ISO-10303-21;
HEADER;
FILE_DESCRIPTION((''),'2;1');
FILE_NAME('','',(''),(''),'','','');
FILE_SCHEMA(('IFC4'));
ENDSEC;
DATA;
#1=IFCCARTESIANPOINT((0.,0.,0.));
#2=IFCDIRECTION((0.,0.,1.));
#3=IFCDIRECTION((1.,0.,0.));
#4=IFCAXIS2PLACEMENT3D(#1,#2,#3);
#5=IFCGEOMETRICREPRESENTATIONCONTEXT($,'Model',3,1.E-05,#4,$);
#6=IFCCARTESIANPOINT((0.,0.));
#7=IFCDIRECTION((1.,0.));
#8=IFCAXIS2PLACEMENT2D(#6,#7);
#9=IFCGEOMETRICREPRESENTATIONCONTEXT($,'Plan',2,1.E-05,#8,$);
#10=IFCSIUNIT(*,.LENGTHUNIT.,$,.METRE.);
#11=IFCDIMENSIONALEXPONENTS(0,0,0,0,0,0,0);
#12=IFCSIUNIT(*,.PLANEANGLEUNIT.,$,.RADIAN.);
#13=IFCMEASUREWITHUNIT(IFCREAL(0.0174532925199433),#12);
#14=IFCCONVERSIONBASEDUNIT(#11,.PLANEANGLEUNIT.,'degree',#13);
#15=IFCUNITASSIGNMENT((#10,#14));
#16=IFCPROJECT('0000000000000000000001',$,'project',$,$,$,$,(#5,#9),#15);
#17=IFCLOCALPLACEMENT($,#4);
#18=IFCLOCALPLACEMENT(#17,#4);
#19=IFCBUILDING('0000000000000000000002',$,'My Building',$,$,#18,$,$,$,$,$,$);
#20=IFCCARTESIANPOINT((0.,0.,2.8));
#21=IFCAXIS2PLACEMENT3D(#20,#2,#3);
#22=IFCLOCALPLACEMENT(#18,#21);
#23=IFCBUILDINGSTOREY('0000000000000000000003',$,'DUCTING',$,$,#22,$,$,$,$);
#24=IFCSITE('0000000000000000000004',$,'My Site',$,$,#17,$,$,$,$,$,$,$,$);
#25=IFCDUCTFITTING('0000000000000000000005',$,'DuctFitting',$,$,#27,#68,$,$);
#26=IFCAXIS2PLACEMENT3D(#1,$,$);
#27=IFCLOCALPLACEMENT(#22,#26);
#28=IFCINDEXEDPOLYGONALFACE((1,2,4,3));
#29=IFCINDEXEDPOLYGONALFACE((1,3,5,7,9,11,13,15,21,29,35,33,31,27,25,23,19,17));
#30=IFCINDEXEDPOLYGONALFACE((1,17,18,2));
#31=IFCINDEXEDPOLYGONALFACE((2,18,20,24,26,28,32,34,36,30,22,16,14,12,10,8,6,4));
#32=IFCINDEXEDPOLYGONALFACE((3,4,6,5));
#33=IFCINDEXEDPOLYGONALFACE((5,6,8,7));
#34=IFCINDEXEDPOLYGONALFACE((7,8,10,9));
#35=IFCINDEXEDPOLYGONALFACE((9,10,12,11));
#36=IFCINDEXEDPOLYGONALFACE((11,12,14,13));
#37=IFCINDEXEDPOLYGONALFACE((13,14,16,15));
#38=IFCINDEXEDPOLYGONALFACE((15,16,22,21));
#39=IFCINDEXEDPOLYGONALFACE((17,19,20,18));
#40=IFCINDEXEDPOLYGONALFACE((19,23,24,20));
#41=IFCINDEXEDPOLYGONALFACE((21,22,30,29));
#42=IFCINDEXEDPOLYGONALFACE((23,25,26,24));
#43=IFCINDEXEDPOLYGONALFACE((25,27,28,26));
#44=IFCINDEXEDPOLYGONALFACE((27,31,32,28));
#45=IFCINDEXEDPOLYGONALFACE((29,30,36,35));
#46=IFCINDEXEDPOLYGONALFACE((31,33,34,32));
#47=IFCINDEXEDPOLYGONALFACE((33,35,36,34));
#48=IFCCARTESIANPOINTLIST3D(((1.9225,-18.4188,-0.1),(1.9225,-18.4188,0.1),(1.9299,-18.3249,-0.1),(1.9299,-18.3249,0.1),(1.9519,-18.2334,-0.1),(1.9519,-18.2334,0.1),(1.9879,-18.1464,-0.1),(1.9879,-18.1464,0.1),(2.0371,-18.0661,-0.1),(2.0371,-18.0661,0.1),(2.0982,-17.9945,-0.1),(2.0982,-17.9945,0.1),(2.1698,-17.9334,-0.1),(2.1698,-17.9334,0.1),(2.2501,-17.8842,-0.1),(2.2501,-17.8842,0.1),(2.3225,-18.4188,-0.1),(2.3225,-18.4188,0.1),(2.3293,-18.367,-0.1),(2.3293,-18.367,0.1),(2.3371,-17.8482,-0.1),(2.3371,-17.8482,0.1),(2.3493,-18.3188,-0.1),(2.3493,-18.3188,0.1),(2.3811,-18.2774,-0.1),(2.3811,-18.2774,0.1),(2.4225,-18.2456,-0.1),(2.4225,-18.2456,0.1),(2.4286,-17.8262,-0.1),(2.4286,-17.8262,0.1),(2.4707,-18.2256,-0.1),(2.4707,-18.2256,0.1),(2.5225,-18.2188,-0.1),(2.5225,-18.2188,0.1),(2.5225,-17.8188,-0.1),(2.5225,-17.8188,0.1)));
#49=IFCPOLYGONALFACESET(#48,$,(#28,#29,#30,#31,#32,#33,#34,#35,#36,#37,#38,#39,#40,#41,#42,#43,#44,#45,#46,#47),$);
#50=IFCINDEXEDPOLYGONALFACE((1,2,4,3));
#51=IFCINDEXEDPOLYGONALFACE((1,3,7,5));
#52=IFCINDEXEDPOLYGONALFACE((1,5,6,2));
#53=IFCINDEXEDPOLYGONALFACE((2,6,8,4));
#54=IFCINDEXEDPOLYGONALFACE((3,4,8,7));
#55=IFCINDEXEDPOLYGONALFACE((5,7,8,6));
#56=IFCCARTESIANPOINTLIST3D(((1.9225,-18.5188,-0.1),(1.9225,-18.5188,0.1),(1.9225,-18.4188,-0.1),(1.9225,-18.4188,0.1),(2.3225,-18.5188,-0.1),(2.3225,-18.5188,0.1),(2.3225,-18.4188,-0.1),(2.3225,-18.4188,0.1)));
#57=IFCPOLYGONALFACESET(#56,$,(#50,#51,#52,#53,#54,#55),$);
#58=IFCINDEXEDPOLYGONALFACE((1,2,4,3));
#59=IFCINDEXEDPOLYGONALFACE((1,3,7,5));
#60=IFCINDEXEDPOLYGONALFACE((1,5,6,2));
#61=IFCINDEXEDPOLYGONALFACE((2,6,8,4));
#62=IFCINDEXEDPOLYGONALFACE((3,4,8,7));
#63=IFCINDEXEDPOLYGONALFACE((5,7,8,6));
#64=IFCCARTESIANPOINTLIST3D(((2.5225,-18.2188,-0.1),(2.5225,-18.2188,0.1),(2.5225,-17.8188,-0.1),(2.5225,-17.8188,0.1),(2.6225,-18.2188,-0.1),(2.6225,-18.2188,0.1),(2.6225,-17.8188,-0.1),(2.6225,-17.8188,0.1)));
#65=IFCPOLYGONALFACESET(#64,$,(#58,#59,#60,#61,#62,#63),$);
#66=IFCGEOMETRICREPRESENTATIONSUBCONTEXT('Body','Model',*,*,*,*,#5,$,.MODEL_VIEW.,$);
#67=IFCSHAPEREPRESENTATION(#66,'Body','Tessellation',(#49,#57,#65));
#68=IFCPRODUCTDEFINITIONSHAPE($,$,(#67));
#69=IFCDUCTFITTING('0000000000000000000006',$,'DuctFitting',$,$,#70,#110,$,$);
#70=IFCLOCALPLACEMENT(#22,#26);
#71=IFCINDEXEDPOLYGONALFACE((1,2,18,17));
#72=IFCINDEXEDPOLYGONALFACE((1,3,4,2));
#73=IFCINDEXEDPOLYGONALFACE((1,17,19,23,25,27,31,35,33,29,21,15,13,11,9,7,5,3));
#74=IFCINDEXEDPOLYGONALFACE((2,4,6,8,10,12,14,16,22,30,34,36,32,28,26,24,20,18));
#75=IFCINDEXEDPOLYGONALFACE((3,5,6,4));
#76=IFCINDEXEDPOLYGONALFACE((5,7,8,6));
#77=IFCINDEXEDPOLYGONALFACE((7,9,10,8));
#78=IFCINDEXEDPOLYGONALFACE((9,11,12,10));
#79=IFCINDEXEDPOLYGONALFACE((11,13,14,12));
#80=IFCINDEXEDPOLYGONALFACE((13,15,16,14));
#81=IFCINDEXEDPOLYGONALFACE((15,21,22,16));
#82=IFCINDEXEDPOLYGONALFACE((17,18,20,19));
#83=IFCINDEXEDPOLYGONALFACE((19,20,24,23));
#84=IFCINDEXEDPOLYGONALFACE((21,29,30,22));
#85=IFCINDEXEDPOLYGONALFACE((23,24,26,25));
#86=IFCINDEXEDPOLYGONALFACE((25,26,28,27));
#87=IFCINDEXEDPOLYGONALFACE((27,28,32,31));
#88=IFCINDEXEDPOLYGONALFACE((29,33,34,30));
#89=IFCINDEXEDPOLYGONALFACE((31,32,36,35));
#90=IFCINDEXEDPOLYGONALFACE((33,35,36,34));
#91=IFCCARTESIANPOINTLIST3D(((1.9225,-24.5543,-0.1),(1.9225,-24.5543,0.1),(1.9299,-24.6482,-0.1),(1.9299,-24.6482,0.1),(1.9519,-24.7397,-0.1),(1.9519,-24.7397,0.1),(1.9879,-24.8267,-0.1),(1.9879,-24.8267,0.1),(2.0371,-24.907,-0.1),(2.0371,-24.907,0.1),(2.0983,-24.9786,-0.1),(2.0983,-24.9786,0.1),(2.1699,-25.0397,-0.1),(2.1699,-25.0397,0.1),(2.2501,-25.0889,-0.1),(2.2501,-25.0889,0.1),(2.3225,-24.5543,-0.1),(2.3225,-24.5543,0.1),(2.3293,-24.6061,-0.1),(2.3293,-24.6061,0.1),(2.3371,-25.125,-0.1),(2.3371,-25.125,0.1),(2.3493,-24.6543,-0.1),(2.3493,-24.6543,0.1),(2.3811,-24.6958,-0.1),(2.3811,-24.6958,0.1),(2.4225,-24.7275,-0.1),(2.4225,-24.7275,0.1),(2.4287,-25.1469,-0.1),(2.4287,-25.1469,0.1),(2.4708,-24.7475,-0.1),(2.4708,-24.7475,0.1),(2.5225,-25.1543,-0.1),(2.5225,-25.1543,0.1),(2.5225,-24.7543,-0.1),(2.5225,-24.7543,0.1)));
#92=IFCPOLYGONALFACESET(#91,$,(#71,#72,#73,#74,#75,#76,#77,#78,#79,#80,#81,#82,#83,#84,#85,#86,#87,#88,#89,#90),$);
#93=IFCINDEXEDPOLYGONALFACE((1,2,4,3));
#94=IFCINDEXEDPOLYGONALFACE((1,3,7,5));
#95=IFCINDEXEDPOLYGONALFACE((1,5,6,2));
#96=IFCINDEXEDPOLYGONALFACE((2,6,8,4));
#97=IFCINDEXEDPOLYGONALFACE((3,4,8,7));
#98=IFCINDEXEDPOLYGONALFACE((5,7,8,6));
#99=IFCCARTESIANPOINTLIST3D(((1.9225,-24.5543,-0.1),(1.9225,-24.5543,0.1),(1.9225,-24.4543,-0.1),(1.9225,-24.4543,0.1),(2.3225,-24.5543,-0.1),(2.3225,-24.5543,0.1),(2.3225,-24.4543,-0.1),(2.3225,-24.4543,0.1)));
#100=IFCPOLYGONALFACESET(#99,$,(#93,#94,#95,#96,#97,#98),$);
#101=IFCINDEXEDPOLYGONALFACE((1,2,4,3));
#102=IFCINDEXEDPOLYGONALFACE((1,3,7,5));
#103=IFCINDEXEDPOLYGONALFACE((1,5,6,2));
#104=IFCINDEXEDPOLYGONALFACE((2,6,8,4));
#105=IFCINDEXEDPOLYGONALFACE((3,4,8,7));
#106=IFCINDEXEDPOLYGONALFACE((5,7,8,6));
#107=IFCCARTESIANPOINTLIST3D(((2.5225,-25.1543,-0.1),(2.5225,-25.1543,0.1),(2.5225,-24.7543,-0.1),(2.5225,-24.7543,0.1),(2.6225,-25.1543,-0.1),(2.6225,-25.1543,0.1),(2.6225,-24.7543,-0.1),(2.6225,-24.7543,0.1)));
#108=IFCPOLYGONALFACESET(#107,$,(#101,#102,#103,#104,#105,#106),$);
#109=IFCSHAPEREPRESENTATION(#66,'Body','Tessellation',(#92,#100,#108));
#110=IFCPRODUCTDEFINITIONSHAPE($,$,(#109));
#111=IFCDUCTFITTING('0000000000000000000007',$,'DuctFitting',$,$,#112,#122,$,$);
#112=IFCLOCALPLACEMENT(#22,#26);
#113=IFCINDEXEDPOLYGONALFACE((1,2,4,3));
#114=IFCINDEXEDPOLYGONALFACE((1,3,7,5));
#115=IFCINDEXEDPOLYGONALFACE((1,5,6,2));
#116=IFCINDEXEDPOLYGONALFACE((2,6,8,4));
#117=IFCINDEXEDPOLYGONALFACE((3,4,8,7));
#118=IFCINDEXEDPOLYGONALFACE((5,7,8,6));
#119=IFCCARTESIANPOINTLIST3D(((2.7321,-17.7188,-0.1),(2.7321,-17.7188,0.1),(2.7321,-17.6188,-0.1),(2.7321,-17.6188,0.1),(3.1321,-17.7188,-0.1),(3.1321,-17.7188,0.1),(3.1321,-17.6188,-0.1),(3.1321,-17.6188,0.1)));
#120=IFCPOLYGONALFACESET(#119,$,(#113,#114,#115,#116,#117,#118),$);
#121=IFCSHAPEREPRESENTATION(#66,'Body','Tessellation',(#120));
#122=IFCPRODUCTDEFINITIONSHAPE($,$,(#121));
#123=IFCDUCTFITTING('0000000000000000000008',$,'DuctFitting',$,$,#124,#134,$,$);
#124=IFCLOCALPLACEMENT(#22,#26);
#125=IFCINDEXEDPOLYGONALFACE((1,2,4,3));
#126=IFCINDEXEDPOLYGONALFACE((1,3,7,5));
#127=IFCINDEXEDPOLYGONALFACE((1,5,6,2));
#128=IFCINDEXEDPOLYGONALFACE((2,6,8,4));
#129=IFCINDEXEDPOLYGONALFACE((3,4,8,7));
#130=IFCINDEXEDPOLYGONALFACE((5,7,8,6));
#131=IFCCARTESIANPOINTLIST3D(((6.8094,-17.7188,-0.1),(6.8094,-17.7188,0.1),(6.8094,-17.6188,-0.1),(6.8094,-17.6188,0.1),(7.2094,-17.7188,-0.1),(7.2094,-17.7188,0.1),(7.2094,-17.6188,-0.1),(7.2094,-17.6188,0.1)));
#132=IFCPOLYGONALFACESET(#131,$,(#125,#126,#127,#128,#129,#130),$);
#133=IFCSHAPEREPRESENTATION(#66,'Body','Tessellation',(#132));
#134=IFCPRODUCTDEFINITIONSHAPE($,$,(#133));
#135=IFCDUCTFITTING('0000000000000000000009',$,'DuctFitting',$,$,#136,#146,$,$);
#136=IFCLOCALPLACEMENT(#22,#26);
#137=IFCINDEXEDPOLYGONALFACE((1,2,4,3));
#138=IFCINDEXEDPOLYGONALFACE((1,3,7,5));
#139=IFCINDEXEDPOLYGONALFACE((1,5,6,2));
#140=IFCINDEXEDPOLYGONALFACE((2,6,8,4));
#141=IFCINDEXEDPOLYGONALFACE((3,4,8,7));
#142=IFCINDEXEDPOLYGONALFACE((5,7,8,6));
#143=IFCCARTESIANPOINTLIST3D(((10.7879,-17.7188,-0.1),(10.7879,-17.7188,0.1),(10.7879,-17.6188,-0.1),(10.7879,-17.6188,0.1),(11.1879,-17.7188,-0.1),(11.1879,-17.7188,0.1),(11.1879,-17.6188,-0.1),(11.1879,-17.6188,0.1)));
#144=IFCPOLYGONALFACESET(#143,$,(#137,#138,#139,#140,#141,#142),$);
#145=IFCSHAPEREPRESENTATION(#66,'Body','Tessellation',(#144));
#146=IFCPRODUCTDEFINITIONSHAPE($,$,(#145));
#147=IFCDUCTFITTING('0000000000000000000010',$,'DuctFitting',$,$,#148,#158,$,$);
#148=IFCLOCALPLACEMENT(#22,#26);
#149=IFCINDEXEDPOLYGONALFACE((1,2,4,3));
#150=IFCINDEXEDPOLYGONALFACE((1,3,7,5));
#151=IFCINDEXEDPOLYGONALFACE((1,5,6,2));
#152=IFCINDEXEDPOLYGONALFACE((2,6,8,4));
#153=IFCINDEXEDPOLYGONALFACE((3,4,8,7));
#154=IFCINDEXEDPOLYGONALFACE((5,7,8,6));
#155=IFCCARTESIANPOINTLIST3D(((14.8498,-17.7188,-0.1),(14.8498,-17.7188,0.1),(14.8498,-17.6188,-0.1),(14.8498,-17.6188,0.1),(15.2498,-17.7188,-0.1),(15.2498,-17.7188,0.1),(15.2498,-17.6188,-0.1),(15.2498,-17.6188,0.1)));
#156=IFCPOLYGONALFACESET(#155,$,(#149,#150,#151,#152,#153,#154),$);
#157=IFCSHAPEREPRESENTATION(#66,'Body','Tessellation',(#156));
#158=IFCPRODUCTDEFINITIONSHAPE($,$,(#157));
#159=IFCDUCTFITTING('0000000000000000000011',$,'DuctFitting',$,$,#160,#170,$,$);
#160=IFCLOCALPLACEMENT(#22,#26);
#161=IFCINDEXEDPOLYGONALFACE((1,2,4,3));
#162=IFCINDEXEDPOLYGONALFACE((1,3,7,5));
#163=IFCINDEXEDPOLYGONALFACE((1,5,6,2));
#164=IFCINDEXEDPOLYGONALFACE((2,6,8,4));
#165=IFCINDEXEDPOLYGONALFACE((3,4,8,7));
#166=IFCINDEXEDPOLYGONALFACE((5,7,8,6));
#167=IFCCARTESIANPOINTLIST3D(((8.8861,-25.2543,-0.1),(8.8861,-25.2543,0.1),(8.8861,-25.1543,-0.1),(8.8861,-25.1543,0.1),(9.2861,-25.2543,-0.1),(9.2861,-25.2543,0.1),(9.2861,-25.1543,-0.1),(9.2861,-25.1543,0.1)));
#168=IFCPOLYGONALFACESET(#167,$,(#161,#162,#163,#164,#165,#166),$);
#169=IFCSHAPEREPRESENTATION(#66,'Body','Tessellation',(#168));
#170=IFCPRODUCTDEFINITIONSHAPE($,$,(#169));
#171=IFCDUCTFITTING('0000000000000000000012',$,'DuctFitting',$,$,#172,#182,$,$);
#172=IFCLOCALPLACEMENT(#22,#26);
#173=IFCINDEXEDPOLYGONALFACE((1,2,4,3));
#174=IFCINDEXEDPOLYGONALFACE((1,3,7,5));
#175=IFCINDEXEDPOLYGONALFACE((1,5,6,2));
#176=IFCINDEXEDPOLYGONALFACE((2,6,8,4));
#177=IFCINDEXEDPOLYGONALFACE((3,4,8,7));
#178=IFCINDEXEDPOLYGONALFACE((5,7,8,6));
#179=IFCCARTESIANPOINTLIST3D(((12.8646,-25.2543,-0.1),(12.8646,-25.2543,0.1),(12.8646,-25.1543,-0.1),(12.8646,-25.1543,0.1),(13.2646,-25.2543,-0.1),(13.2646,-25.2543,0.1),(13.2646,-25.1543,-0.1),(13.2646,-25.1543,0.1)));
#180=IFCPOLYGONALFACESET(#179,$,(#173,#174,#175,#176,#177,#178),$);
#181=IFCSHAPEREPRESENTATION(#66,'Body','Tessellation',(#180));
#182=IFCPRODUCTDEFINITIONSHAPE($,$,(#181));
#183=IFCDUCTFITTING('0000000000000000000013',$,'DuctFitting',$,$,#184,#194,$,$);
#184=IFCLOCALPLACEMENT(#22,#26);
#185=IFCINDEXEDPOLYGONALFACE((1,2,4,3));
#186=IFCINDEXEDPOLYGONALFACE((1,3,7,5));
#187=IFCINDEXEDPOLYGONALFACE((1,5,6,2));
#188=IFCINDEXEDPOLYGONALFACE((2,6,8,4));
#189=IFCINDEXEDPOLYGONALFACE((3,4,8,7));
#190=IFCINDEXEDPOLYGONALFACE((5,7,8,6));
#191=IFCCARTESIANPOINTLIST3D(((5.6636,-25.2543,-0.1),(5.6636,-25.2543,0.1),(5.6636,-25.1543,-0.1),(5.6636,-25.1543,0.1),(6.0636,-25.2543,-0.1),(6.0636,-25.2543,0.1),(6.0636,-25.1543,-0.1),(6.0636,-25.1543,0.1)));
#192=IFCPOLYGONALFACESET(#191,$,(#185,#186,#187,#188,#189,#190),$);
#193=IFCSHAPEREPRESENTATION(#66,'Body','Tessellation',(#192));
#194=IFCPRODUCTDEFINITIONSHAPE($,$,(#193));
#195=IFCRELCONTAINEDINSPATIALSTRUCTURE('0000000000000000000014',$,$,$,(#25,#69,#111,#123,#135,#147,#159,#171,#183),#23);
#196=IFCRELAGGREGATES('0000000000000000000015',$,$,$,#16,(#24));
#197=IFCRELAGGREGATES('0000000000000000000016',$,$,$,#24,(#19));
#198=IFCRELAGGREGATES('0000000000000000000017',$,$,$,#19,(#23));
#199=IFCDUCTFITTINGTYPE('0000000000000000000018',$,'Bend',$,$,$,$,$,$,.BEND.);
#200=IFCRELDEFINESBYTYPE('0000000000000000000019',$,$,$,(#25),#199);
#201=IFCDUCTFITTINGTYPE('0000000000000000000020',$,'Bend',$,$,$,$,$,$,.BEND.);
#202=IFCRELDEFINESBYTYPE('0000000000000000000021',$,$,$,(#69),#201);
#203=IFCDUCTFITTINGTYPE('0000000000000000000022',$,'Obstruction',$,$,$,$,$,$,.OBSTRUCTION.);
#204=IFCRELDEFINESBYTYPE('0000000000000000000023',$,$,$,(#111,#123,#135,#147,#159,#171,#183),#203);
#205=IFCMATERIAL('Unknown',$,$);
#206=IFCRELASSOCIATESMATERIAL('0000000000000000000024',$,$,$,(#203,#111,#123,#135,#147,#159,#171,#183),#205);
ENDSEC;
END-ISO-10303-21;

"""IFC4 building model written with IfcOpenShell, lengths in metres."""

from ifc_helpers import new_model, entity, si_unit, converted_unit, frame, origin_with_axes, origin_2d_with_axis, place, context, subcontext, project, spatial, line, arc, indexed_curve, rectangle, outline, extrude, source, transform, mapped, material, material_profile, profile_set, profile_usage, type_object, type_shapes, element, save


model = new_model("IFC4")

# Units and contexts
model_context = context("Model", 3, precision=1e-05, world=origin_with_axes())
plan_context = context("Plan", 2, precision=1e-05, world=origin_2d_with_axis())
body_context = subcontext(model_context, "Body", "Model", "MODEL_VIEW")
ifc_project = project(units=[si_unit("LENGTHUNIT", "METRE"), converted_unit("PLANEANGLEUNIT", "degree", entity("IfcReal", 0.0174532925199433), si_unit("PLANEANGLEUNIT", "RADIAN"), dimensions=[0, 0, 0, 0, 0, 0, 0])], contexts=[model_context, plan_context])

# Site, building, storey
site_placement = place(None, origin_with_axes())
site = spatial("IfcSite", under=ifc_project, at=site_placement, Name="My Site")
building_placement = place(site_placement, origin_with_axes())
building = spatial("IfcBuilding", under=site, at=building_placement, Name="My Building")
storey_placement = place(building_placement, frame((0.0, 0.0, 2.8), z_axis=(0.0, 0.0, 1.0), x_axis=(1.0, 0.0, 0.0)))
storey = spatial("IfcBuildingStorey", under=building, at=storey_placement, Name="DUCTING")

# Shared definitions
ifc_material = material(Name="Unknown")

# Duct fittings
duct_fitting_type_1 = type_object("IfcDuctFittingType", Name="Bend", PredefinedType="BEND")
shared_shape_1 = source(origin_with_axes(), body_context, "Body", "SweptSolid", [
    extrude(outline(indexed_curve([(-0.2, 0.0), (-0.2586, 0.1414), (-0.4, 0.2), (-0.4, 0.6), (0.0243, 0.4243), (0.2, 0.0)], segments=[arc(1, 2, 3), line(3, 4), arc(4, 5, 6), line(6, 1)])), frame((0.0, -0.1, 0.1), z_axis=(0.0, -1.0, 0.0), x_axis=(1.0, 0.0, 0.0)), (0.0, 0.0, -1.0), 0.2),
    extrude(rectangle(XDim=0.4, YDim=0.2), origin_with_axes(), (0.0, 0.0, 1.0), 0.1),
    extrude(rectangle(XDim=0.4, YDim=0.2), frame((-0.4, 0.0, 0.5), z_axis=(-1.0, 0.0, -0.000007), x_axis=(0.000007, 0.0, -1.0)), (0.0, 0.0, 1.0), 0.1),
])
type_shapes(duct_fitting_type_1, [shared_shape_1])
duct_fitting_1_placement = place(storey_placement, frame((2.1225, -18.5188, 0.0), z_axis=(-0.000006, 1.0, 0.0), x_axis=(-1.0, -0.000006, 0.0)))
element("IfcDuctFitting", 1, at=duct_fitting_1_placement, inside=storey, type_object=duct_fitting_type_1, Name="DuctFitting", context=body_context, shape_type="MappedRepresentation", body=[
    mapped(shared_shape_1, transform((0.0, 0.0, 0.0), x_axis=(1.0, 0.0, 0.0), y_axis=(0.0, 1.0, 0.0), z_axis=(0.0, 0.0, 1.0), scale=1.0)),
])
duct_fitting_type_2 = type_object("IfcDuctFittingType", Name="Bend", PredefinedType="BEND")
shared_shape_2 = source(origin_with_axes(), body_context, "Body", "SweptSolid", [
    extrude(outline(indexed_curve([(-0.2, 0.0), (-0.2586, -0.1414), (-0.4, -0.2), (-0.4, -0.6), (0.0243, -0.4243), (0.2, 0.0)], segments=[arc(1, 2, 3), line(3, 4), arc(4, 5, 6), line(6, 1)])), frame((0.0, -0.1, -0.1), z_axis=(0.0, -1.0, 0.0), x_axis=(1.0, 0.0, 0.0)), (0.0, 0.0, -1.0), 0.2),
    extrude(rectangle(XDim=0.4, YDim=0.2), origin_with_axes(), (0.0, 0.0, -1.0), 0.1),
    extrude(rectangle(XDim=0.4, YDim=0.2), frame((-0.4, 0.0, -0.5), z_axis=(-1.0, 0.0, -0.000007), x_axis=(0.000007, 0.0, -1.0)), (0.0, 0.0, 1.0), 0.1),
])
type_shapes(duct_fitting_type_2, [shared_shape_2])
duct_fitting_2_placement = place(storey_placement, frame((2.1225, -24.4543, 0.0), z_axis=(-0.000006, 1.0, 0.0), x_axis=(-1.0, -0.000006, 0.0)))
element("IfcDuctFitting", 2, at=duct_fitting_2_placement, inside=storey, type_object=duct_fitting_type_2, Name="DuctFitting", context=body_context, shape_type="MappedRepresentation", body=[
    mapped(shared_shape_2, transform((0.0, 0.0, 0.0), x_axis=(1.0, 0.0, 0.0), y_axis=(0.0, 1.0, 0.0), z_axis=(0.0, 0.0, 1.0), scale=1.0)),
])
ifc_material_profile_1 = material_profile(ifc_material, rectangle(XDim=0.4, YDim=0.2))
ifc_profile_set_1 = profile_set([ifc_material_profile_1])
ifc_profile_usage_1 = profile_usage(ifc_profile_set_1, cardinal=5)
duct_fitting_type_3 = type_object("IfcDuctFittingType", Name="Obstruction", PredefinedType="OBSTRUCTION", material=ifc_profile_set_1)
duct_fitting_3_placement = place(storey_placement, frame((2.9321, -17.7188, 0.0), z_axis=(0.0, 1.0, 0.0), x_axis=(-1.0, 0.0, 0.0)))
element("IfcDuctFitting", 3, at=duct_fitting_3_placement, inside=storey, type_object=duct_fitting_type_3, material=ifc_profile_usage_1, Name="DuctFitting", context=body_context, shape_type="SweptSolid", body=[
    extrude(rectangle(XDim=0.4, YDim=0.2), origin_with_axes(), (0.0, 0.0, 1.0), 0.1),
])
ifc_profile_usage_2 = profile_usage(ifc_profile_set_1, cardinal=5)
duct_fitting_4_placement = place(storey_placement, frame((7.0094, -17.7188, 0.0), z_axis=(0.0, 1.0, 0.0), x_axis=(-1.0, 0.0, 0.0)))
element("IfcDuctFitting", 4, at=duct_fitting_4_placement, inside=storey, type_object=duct_fitting_type_3, material=ifc_profile_usage_2, Name="DuctFitting", context=body_context, shape_type="SweptSolid", body=[
    extrude(rectangle(XDim=0.4, YDim=0.2), origin_with_axes(), (0.0, 0.0, 1.0), 0.1),
])
ifc_profile_usage_3 = profile_usage(ifc_profile_set_1, cardinal=5)
duct_fitting_5_placement = place(storey_placement, frame((10.9879, -17.7188, 0.0), z_axis=(0.0, 1.0, 0.0), x_axis=(-1.0, 0.0, 0.0)))
element("IfcDuctFitting", 5, at=duct_fitting_5_placement, inside=storey, type_object=duct_fitting_type_3, material=ifc_profile_usage_3, Name="DuctFitting", context=body_context, shape_type="SweptSolid", body=[
    extrude(rectangle(XDim=0.4, YDim=0.2), origin_with_axes(), (0.0, 0.0, 1.0), 0.1),
])
ifc_profile_usage_4 = profile_usage(ifc_profile_set_1, cardinal=5)
duct_fitting_6_placement = place(storey_placement, frame((15.0498, -17.7188, 0.0), z_axis=(0.0, 1.0, 0.0), x_axis=(-1.0, 0.0, 0.0)))
element("IfcDuctFitting", 6, at=duct_fitting_6_placement, inside=storey, type_object=duct_fitting_type_3, material=ifc_profile_usage_4, Name="DuctFitting", context=body_context, shape_type="SweptSolid", body=[
    extrude(rectangle(XDim=0.4, YDim=0.2), origin_with_axes(), (0.0, 0.0, 1.0), 0.1),
])
ifc_profile_usage_5 = profile_usage(ifc_profile_set_1, cardinal=5)
duct_fitting_7_placement = place(storey_placement, frame((9.0861, -25.1543, 0.0), z_axis=(0.0, -1.0, 0.0), x_axis=(1.0, 0.0, 0.0)))
element("IfcDuctFitting", 7, at=duct_fitting_7_placement, inside=storey, type_object=duct_fitting_type_3, material=ifc_profile_usage_5, Name="DuctFitting", context=body_context, shape_type="SweptSolid", body=[
    extrude(rectangle(XDim=0.4, YDim=0.2), origin_with_axes(), (0.0, 0.0, 1.0), 0.1),
])
ifc_profile_usage_6 = profile_usage(ifc_profile_set_1, cardinal=5)
duct_fitting_8_placement = place(storey_placement, frame((13.0646, -25.1543, 0.0), z_axis=(0.0, -1.0, 0.0), x_axis=(1.0, 0.0, 0.0)))
element("IfcDuctFitting", 8, at=duct_fitting_8_placement, inside=storey, type_object=duct_fitting_type_3, material=ifc_profile_usage_6, Name="DuctFitting", context=body_context, shape_type="SweptSolid", body=[
    extrude(rectangle(XDim=0.4, YDim=0.2), origin_with_axes(), (0.0, 0.0, 1.0), 0.1),
])
ifc_profile_usage_7 = profile_usage(ifc_profile_set_1, cardinal=5)
duct_fitting_9_placement = place(storey_placement, frame((5.8636, -25.1543, 0.0), z_axis=(0.0, -1.0, 0.0), x_axis=(1.0, 0.0, 0.0)))
element("IfcDuctFitting", 9, at=duct_fitting_9_placement, inside=storey, type_object=duct_fitting_type_3, material=ifc_profile_usage_7, Name="DuctFitting", context=body_context, shape_type="SweptSolid", body=[
    extrude(rectangle(XDim=0.4, YDim=0.2), origin_with_axes(), (0.0, 0.0, 1.0), 0.1),
])

save(model, "model.ifc")
